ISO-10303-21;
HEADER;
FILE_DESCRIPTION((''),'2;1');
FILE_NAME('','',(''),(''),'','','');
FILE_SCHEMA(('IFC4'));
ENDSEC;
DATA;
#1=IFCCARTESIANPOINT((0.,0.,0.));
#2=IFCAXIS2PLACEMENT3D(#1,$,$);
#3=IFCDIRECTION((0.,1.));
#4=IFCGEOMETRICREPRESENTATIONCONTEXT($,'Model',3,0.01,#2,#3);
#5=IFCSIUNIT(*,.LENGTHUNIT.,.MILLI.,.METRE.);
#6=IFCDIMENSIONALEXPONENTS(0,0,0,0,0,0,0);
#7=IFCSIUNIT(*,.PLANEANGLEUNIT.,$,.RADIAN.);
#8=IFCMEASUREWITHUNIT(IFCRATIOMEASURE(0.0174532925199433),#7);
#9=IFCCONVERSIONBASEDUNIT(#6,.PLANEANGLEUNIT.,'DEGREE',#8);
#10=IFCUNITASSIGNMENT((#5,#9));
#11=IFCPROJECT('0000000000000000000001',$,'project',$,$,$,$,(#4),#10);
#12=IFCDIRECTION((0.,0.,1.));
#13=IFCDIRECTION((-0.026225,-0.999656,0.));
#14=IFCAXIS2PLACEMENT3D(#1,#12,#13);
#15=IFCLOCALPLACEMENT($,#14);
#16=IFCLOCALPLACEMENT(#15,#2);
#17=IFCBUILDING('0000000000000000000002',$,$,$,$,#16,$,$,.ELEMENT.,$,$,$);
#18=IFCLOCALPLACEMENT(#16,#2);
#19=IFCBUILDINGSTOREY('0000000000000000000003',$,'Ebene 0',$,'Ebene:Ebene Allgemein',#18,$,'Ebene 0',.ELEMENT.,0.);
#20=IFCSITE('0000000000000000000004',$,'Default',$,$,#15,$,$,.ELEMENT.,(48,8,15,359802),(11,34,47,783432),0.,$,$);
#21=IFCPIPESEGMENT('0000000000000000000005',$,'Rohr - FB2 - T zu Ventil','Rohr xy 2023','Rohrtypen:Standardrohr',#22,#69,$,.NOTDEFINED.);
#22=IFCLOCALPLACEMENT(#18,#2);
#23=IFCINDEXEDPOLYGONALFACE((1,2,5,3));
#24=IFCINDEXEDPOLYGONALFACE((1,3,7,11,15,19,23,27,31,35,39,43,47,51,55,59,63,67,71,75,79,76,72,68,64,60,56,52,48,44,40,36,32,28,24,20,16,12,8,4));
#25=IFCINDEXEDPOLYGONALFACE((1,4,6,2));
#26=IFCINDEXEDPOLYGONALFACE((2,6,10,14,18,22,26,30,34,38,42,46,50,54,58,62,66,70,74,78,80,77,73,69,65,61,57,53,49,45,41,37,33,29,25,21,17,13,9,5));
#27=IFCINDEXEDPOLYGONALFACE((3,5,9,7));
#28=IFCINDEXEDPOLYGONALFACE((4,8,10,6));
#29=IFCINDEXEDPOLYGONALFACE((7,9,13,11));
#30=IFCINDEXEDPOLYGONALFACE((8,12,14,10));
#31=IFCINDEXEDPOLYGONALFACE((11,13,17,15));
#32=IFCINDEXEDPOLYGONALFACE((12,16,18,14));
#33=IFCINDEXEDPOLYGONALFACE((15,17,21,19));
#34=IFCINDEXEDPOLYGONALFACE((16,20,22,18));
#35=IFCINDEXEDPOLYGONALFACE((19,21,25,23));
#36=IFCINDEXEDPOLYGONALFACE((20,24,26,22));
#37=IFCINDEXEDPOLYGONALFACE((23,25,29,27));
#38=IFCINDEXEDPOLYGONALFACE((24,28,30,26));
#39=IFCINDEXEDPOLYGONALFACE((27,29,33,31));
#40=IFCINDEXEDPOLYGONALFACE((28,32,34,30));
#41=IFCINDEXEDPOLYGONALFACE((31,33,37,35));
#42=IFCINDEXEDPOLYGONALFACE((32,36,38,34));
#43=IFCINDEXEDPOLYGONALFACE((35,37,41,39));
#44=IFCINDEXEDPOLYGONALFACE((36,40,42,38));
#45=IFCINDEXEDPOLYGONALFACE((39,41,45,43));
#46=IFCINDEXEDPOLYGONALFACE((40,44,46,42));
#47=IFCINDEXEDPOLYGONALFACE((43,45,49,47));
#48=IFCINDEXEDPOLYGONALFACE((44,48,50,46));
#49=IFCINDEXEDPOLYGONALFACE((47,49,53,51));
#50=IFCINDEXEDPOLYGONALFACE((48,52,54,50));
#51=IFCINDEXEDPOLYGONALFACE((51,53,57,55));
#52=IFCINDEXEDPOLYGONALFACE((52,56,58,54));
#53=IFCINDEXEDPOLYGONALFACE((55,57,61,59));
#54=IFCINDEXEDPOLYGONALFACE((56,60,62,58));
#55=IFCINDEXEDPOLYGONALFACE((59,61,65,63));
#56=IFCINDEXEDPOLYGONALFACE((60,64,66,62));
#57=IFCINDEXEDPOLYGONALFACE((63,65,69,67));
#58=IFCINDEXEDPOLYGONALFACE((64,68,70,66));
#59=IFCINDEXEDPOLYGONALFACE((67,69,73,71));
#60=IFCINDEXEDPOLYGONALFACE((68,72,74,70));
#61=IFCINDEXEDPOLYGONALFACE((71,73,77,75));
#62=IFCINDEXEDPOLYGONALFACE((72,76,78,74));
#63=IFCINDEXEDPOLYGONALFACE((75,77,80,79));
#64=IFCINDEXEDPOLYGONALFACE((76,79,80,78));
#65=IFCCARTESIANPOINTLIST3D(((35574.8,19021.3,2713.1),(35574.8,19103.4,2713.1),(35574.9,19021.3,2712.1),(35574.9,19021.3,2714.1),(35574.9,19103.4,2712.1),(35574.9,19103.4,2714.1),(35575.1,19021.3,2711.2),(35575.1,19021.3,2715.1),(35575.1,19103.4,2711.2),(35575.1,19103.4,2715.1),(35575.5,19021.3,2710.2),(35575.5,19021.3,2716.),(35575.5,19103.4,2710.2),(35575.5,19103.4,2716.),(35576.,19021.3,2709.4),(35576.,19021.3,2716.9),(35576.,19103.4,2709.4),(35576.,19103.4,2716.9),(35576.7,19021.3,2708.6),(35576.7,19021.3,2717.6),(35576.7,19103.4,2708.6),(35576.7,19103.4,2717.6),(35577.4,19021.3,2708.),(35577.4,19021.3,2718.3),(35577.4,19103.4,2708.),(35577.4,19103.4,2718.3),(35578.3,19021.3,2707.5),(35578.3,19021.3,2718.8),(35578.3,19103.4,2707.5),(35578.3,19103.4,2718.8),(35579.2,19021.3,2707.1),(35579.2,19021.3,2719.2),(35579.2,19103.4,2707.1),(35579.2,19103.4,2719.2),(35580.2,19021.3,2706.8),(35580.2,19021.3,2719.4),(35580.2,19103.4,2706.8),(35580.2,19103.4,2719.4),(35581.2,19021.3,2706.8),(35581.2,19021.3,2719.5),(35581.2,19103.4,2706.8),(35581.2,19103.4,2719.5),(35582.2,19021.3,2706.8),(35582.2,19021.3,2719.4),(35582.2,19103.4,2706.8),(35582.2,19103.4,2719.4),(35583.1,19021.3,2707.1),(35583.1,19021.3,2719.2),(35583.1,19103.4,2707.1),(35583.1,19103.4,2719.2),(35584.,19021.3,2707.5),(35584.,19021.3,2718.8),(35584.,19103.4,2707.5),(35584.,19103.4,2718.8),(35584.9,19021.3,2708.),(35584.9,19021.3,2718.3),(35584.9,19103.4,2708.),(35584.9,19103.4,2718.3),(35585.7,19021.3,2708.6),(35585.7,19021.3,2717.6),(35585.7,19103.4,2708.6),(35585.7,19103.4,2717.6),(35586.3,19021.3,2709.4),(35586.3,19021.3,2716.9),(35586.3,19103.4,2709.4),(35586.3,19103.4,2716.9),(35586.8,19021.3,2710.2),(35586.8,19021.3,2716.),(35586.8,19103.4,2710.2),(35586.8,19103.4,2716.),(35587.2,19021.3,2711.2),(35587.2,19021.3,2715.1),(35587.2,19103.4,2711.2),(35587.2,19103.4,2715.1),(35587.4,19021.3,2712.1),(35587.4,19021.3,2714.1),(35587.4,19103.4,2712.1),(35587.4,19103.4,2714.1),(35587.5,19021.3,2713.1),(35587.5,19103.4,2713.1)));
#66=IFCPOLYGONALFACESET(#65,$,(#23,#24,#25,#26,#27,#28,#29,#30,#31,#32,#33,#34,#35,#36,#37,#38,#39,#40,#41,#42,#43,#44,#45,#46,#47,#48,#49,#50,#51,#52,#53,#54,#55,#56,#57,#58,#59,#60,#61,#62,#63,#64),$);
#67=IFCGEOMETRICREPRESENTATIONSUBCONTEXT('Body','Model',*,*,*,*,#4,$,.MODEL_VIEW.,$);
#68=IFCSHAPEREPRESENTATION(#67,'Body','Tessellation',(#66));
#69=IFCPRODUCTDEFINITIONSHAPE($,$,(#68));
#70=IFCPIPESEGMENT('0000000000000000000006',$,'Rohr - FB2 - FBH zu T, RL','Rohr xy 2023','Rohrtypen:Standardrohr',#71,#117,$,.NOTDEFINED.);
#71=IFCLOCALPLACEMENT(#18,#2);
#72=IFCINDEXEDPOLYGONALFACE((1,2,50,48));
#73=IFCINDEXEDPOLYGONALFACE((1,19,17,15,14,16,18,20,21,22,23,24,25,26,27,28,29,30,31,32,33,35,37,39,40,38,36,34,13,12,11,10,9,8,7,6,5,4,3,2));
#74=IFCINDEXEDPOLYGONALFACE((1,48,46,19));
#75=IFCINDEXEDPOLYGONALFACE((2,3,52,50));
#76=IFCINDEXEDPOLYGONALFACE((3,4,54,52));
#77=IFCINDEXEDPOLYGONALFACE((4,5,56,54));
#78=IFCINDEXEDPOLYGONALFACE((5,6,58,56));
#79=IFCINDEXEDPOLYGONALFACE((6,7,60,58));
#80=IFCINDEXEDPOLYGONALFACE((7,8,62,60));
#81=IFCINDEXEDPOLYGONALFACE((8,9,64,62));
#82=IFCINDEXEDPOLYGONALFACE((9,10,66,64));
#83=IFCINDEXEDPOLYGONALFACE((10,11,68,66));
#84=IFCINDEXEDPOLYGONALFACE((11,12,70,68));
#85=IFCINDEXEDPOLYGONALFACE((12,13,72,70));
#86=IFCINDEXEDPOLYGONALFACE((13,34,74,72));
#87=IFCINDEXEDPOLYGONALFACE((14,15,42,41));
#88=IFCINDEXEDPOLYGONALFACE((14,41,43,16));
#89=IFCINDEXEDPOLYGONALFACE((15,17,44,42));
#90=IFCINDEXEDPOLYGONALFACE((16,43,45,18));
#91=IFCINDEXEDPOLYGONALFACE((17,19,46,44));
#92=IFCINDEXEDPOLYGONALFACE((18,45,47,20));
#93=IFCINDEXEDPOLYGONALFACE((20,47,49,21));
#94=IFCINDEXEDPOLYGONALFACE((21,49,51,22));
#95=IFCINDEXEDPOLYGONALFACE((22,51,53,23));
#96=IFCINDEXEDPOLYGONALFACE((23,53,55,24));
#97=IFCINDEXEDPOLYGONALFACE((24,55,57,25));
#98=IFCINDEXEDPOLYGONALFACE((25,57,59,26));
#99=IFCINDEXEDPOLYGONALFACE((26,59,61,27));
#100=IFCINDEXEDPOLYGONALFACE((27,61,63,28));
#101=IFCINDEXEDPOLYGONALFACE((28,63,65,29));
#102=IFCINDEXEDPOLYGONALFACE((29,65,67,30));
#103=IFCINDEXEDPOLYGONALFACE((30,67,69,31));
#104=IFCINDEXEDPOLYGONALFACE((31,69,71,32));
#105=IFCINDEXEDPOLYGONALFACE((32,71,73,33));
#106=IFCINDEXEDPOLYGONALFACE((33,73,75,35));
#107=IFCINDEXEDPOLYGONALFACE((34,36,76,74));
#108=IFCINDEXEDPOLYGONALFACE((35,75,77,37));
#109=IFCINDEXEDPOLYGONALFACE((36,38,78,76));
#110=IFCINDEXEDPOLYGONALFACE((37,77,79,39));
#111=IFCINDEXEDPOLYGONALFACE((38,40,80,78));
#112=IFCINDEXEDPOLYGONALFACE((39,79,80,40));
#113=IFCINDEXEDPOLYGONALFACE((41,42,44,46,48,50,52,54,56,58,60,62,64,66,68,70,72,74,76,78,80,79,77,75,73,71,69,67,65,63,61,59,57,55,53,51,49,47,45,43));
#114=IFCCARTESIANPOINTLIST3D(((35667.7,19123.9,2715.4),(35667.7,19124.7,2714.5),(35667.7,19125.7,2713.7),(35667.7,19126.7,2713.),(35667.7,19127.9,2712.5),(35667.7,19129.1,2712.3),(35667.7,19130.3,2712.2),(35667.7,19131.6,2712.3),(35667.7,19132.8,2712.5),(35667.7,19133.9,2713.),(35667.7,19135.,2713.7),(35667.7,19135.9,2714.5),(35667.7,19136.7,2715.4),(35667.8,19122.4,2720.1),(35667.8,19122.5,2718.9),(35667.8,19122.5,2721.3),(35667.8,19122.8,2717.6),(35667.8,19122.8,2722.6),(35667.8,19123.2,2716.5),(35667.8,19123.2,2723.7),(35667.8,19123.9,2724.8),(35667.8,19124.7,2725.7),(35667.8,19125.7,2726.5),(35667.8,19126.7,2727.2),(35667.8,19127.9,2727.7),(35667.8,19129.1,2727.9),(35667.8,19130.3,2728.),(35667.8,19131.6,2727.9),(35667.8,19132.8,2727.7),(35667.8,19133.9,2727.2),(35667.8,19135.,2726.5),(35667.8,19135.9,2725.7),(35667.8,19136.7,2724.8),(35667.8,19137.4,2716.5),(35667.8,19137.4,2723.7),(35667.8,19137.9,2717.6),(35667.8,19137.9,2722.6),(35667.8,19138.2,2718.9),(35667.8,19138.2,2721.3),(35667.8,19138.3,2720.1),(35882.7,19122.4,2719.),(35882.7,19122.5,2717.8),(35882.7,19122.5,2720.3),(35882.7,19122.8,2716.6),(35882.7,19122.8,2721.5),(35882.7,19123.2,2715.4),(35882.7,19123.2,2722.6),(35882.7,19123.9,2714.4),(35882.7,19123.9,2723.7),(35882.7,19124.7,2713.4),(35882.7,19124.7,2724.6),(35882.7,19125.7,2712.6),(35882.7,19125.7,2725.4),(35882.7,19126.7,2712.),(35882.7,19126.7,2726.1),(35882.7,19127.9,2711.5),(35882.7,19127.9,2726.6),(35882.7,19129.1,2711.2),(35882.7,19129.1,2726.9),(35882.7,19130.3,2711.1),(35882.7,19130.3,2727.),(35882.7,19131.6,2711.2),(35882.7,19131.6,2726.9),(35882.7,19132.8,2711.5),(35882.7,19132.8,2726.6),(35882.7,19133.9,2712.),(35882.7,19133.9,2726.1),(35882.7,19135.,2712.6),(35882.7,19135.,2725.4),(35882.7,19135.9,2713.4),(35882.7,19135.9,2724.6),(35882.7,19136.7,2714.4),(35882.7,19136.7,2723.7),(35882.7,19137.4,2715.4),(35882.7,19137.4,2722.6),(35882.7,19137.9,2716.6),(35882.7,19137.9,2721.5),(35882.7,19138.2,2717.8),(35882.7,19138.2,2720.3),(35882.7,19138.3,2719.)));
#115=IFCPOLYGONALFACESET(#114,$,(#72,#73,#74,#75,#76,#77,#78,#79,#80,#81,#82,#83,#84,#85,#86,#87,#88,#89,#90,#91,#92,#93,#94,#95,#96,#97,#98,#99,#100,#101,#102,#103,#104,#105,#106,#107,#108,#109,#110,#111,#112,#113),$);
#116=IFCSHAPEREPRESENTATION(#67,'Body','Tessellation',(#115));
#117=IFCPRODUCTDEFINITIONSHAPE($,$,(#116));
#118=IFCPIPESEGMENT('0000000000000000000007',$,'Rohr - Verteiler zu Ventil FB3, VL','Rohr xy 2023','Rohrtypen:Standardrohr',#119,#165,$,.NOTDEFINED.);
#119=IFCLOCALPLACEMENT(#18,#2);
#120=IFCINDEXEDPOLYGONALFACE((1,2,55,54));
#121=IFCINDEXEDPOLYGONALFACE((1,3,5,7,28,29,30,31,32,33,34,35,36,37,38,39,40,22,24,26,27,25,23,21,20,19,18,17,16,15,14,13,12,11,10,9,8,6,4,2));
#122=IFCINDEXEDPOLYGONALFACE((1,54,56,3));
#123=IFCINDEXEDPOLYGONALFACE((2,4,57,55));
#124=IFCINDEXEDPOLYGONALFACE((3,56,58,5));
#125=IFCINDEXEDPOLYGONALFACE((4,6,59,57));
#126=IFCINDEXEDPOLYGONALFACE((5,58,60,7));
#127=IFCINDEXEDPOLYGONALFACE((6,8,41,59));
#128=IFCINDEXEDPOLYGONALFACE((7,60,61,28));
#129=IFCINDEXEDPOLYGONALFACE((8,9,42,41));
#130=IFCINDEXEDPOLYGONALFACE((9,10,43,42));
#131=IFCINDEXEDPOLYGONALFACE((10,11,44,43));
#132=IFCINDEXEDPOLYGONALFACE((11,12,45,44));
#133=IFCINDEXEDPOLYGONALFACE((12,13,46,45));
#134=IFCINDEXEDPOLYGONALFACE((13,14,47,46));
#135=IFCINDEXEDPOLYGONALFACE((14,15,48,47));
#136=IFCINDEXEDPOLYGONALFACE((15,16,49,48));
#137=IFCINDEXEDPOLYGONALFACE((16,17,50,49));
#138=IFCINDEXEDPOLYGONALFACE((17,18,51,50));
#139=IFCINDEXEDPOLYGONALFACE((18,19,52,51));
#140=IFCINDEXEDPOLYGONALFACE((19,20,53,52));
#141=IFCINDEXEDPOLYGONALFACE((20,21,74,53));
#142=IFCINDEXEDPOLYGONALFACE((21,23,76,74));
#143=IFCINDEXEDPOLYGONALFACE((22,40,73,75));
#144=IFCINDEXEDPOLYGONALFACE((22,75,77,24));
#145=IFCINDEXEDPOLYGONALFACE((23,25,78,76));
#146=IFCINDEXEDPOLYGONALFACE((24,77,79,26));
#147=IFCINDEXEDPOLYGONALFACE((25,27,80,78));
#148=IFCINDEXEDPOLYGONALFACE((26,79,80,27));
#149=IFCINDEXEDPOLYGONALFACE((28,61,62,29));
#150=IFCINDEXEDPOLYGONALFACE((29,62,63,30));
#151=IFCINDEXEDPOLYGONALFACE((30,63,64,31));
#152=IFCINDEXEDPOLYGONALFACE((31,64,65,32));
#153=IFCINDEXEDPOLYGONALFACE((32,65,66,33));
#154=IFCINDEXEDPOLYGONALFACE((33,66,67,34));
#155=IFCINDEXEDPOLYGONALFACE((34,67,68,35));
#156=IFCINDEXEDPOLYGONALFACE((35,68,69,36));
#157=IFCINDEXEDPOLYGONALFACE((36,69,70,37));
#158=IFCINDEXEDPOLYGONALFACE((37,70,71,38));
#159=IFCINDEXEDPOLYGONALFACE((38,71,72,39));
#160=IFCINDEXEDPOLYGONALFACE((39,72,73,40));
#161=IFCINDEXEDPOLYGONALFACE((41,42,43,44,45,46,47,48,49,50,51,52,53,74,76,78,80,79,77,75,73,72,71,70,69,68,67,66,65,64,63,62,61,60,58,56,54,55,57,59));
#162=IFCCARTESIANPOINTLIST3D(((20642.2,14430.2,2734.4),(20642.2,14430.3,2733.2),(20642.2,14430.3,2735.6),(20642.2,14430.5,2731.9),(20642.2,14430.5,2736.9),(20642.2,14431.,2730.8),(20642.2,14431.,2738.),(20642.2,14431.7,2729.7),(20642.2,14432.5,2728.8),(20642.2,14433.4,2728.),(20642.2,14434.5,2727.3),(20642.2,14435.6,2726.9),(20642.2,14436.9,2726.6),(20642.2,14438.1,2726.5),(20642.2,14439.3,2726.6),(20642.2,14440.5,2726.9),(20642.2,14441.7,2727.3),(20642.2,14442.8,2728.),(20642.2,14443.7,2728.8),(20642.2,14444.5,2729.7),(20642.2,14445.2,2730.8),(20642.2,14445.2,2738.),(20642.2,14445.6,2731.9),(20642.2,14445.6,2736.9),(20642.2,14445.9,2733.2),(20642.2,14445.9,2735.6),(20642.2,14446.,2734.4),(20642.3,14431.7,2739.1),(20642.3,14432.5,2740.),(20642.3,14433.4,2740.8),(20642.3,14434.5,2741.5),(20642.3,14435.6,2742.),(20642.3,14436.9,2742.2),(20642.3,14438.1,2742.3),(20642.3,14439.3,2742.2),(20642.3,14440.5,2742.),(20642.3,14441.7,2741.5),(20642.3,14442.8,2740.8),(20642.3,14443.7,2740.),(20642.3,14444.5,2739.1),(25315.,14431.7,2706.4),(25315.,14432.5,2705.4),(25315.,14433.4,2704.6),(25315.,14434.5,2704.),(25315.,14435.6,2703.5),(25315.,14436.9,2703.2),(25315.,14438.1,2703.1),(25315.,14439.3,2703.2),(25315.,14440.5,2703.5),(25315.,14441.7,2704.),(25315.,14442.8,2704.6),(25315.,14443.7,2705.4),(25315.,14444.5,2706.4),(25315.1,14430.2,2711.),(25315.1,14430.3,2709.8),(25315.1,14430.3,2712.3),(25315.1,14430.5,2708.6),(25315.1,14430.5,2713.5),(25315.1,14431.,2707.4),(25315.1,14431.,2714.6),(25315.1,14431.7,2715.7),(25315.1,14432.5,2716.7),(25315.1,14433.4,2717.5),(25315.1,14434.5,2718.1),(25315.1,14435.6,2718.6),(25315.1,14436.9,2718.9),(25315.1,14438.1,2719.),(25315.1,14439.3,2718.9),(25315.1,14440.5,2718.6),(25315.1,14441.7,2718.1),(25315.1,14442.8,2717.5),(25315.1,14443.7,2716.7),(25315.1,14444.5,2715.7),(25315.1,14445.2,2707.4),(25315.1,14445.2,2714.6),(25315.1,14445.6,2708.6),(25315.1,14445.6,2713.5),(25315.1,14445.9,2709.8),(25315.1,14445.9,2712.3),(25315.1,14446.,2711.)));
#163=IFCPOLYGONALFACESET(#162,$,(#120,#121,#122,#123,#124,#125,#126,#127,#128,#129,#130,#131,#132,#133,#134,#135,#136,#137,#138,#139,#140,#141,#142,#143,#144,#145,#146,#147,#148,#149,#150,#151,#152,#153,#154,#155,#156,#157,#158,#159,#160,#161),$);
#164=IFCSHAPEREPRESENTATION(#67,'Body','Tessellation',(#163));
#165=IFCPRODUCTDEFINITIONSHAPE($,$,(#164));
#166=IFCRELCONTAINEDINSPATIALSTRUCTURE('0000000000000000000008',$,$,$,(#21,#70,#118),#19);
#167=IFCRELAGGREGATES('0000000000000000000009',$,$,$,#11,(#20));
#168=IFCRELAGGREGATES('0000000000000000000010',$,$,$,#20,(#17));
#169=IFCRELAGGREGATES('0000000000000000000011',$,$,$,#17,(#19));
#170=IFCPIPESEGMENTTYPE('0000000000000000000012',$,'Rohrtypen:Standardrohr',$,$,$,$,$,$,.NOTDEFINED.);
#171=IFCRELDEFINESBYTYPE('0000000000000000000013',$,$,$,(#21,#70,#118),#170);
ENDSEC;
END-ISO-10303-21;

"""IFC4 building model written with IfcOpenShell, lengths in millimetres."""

from ifc_helpers import new_model, entity, si_unit, converted_unit, direction, frame, origin, place, context, subcontext, project, spatial, indexed_curve, outline, extrude, type_object, element, save


model = new_model("IFC4")

# Units and contexts
model_context = context("Model", 3, precision=0.01, world=origin(), true_north=direction((0.0, 1.0)))
body_context = subcontext(model_context, "Body", "Model", "MODEL_VIEW")
ifc_project = project(units=[si_unit("LENGTHUNIT", "METRE", prefix="MILLI"), converted_unit("PLANEANGLEUNIT", "DEGREE", entity("IfcRatioMeasure", 0.0174532925199433), si_unit("PLANEANGLEUNIT", "RADIAN"), dimensions=[0, 0, 0, 0, 0, 0, 0])], contexts=[model_context])

# Site, building, storey
site_placement = place(None, frame((0.0, 0.0, 0.0), z_axis=(0.0, 0.0, 1.0), x_axis=(-0.026225, -0.999656, 0.0)))
site = spatial("IfcSite", under=ifc_project, at=site_placement, Name="Default", CompositionType="ELEMENT", RefLatitude=(48, 8, 15, 359802), RefLongitude=(11, 34, 47, 783432), RefElevation=0.0)
building_placement = place(site_placement, origin())
building = spatial("IfcBuilding", under=site, at=building_placement, CompositionType="ELEMENT")
storey_placement = place(building_placement, origin())
storey = spatial("IfcBuildingStorey", under=building, at=storey_placement, Name="Ebene 0", ObjectType="Ebene:Ebene Allgemein", LongName="Ebene 0", CompositionType="ELEMENT", Elevation=0.0)

# Pipe segments
pipe_segment_type = type_object("IfcPipeSegmentType", Name="Rohrtypen:Standardrohr", PredefinedType="NOTDEFINED")
pipe_segment_1_placement = place(storey_placement, origin())
element("IfcPipeSegment", 1, at=pipe_segment_1_placement, inside=storey, type_object=pipe_segment_type, Name="Rohr - FB2 - T zu Ventil", Description="Rohr xy 2023", ObjectType="Rohrtypen:Standardrohr", PredefinedType="NOTDEFINED", context=body_context, shape_type="SweptSolid", body=[
    extrude(outline(indexed_curve([(6.3, 0.0), (6.3, 1.0), (6.0, 2.0), (5.7, 2.9), (5.1, 3.7), (4.5, 4.5), (3.7, 5.1), (2.9, 5.7), (2.0, 6.0), (1.0, 6.3), (0.0, 6.4), (-1.0, 6.3), (-2.0, 6.0), (-2.9, 5.7), (-3.7, 5.1), (-4.5, 4.5), (-5.1, 3.7), (-5.7, 2.9), (-6.0, 2.0), (-6.3, 1.0), (-6.3, 0.0), (-6.3, -1.0), (-6.0, -2.0), (-5.7, -2.9), (-5.1, -3.7), (-4.5, -4.5), (-3.7, -5.1), (-2.9, -5.7), (-2.0, -6.0), (-1.0, -6.3), (0.0, -6.4), (1.0, -6.3), (2.0, -6.0), (2.9, -5.7), (3.7, -5.1), (4.5, -4.5), (5.1, -3.7), (5.7, -2.9), (6.0, -2.0), (6.3, -1.0), (6.3, 0.0)], self_intersect=False)), frame((35581.2, 19021.3, 2713.1), z_axis=(0.0, 1.0, 0.0), x_axis=(-1.0, 0.0, 0.0)), (0.0, 0.0, 1.0), 82.2),
])
pipe_segment_2_placement = place(storey_placement, origin())
element("IfcPipeSegment", 2, at=pipe_segment_2_placement, inside=storey, type_object=pipe_segment_type, Name="Rohr - FB2 - FBH zu T, RL", Description="Rohr xy 2023", ObjectType="Rohrtypen:Standardrohr", PredefinedType="NOTDEFINED", context=body_context, shape_type="SweptSolid", body=[
    extrude(outline(indexed_curve([(7.9, 0.0), (7.8, 1.2), (7.6, 2.5), (7.1, 3.6), (6.4, 4.7), (5.6, 5.6), (4.7, 6.4), (3.6, 7.1), (2.5, 7.6), (1.2, 7.8), (0.0, 7.9), (-1.2, 7.8), (-2.5, 7.6), (-3.6, 7.1), (-4.7, 6.4), (-5.6, 5.6), (-6.4, 4.7), (-7.1, 3.6), (-7.6, 2.5), (-7.8, 1.2), (-7.9, 0.0), (-7.8, -1.2), (-7.6, -2.5), (-7.1, -3.6), (-6.4, -4.7), (-5.6, -5.6), (-4.7, -6.4), (-3.6, -7.1), (-2.5, -7.6), (-1.2, -7.8), (0.0, -7.9), (1.2, -7.8), (2.5, -7.6), (3.6, -7.1), (4.7, -6.4), (5.6, -5.6), (6.4, -4.7), (7.1, -3.6), (7.6, -2.5), (7.8, -1.2), (7.9, 0.0)], self_intersect=False)), frame((35882.7, 19130.3, 2719.0), z_axis=(-0.999988, 0.0, 0.005), x_axis=(0.0, 1.0, 0.0)), (0.0, 0.0, 1.0), 214.9),
])
pipe_segment_3_placement = place(storey_placement, origin())
element("IfcPipeSegment", 3, at=pipe_segment_3_placement, inside=storey, type_object=pipe_segment_type, Name="Rohr - Verteiler zu Ventil FB3, VL", Description="Rohr xy 2023", ObjectType="Rohrtypen:Standardrohr", PredefinedType="NOTDEFINED", context=body_context, shape_type="SweptSolid", body=[
    extrude(outline(indexed_curve([(7.9, 0.0), (7.8, 1.2), (7.6, 2.5), (7.1, 3.6), (6.4, 4.7), (5.6, 5.6), (4.7, 6.4), (3.6, 7.1), (2.5, 7.6), (1.2, 7.8), (0.0, 7.9), (-1.2, 7.8), (-2.5, 7.6), (-3.6, 7.1), (-4.7, 6.4), (-5.6, 5.6), (-6.4, 4.7), (-7.1, 3.6), (-7.6, 2.5), (-7.8, 1.2), (-7.9, 0.0), (-7.8, -1.2), (-7.6, -2.5), (-7.1, -3.6), (-6.4, -4.7), (-5.6, -5.6), (-4.7, -6.4), (-3.6, -7.1), (-2.5, -7.6), (-1.2, -7.8), (0.0, -7.9), (1.2, -7.8), (2.5, -7.6), (3.6, -7.1), (4.7, -6.4), (5.6, -5.6), (6.4, -4.7), (7.1, -3.6), (7.6, -2.5), (7.8, -1.2), (7.9, 0.0)], self_intersect=False)), frame((25315.1, 14438.1, 2711.0), z_axis=(-0.999988, 0.0, 0.005), x_axis=(0.0, 1.0, 0.0)), (0.0, 0.0, 1.0), 4672.9),
])

save(model, "model.ifc")
